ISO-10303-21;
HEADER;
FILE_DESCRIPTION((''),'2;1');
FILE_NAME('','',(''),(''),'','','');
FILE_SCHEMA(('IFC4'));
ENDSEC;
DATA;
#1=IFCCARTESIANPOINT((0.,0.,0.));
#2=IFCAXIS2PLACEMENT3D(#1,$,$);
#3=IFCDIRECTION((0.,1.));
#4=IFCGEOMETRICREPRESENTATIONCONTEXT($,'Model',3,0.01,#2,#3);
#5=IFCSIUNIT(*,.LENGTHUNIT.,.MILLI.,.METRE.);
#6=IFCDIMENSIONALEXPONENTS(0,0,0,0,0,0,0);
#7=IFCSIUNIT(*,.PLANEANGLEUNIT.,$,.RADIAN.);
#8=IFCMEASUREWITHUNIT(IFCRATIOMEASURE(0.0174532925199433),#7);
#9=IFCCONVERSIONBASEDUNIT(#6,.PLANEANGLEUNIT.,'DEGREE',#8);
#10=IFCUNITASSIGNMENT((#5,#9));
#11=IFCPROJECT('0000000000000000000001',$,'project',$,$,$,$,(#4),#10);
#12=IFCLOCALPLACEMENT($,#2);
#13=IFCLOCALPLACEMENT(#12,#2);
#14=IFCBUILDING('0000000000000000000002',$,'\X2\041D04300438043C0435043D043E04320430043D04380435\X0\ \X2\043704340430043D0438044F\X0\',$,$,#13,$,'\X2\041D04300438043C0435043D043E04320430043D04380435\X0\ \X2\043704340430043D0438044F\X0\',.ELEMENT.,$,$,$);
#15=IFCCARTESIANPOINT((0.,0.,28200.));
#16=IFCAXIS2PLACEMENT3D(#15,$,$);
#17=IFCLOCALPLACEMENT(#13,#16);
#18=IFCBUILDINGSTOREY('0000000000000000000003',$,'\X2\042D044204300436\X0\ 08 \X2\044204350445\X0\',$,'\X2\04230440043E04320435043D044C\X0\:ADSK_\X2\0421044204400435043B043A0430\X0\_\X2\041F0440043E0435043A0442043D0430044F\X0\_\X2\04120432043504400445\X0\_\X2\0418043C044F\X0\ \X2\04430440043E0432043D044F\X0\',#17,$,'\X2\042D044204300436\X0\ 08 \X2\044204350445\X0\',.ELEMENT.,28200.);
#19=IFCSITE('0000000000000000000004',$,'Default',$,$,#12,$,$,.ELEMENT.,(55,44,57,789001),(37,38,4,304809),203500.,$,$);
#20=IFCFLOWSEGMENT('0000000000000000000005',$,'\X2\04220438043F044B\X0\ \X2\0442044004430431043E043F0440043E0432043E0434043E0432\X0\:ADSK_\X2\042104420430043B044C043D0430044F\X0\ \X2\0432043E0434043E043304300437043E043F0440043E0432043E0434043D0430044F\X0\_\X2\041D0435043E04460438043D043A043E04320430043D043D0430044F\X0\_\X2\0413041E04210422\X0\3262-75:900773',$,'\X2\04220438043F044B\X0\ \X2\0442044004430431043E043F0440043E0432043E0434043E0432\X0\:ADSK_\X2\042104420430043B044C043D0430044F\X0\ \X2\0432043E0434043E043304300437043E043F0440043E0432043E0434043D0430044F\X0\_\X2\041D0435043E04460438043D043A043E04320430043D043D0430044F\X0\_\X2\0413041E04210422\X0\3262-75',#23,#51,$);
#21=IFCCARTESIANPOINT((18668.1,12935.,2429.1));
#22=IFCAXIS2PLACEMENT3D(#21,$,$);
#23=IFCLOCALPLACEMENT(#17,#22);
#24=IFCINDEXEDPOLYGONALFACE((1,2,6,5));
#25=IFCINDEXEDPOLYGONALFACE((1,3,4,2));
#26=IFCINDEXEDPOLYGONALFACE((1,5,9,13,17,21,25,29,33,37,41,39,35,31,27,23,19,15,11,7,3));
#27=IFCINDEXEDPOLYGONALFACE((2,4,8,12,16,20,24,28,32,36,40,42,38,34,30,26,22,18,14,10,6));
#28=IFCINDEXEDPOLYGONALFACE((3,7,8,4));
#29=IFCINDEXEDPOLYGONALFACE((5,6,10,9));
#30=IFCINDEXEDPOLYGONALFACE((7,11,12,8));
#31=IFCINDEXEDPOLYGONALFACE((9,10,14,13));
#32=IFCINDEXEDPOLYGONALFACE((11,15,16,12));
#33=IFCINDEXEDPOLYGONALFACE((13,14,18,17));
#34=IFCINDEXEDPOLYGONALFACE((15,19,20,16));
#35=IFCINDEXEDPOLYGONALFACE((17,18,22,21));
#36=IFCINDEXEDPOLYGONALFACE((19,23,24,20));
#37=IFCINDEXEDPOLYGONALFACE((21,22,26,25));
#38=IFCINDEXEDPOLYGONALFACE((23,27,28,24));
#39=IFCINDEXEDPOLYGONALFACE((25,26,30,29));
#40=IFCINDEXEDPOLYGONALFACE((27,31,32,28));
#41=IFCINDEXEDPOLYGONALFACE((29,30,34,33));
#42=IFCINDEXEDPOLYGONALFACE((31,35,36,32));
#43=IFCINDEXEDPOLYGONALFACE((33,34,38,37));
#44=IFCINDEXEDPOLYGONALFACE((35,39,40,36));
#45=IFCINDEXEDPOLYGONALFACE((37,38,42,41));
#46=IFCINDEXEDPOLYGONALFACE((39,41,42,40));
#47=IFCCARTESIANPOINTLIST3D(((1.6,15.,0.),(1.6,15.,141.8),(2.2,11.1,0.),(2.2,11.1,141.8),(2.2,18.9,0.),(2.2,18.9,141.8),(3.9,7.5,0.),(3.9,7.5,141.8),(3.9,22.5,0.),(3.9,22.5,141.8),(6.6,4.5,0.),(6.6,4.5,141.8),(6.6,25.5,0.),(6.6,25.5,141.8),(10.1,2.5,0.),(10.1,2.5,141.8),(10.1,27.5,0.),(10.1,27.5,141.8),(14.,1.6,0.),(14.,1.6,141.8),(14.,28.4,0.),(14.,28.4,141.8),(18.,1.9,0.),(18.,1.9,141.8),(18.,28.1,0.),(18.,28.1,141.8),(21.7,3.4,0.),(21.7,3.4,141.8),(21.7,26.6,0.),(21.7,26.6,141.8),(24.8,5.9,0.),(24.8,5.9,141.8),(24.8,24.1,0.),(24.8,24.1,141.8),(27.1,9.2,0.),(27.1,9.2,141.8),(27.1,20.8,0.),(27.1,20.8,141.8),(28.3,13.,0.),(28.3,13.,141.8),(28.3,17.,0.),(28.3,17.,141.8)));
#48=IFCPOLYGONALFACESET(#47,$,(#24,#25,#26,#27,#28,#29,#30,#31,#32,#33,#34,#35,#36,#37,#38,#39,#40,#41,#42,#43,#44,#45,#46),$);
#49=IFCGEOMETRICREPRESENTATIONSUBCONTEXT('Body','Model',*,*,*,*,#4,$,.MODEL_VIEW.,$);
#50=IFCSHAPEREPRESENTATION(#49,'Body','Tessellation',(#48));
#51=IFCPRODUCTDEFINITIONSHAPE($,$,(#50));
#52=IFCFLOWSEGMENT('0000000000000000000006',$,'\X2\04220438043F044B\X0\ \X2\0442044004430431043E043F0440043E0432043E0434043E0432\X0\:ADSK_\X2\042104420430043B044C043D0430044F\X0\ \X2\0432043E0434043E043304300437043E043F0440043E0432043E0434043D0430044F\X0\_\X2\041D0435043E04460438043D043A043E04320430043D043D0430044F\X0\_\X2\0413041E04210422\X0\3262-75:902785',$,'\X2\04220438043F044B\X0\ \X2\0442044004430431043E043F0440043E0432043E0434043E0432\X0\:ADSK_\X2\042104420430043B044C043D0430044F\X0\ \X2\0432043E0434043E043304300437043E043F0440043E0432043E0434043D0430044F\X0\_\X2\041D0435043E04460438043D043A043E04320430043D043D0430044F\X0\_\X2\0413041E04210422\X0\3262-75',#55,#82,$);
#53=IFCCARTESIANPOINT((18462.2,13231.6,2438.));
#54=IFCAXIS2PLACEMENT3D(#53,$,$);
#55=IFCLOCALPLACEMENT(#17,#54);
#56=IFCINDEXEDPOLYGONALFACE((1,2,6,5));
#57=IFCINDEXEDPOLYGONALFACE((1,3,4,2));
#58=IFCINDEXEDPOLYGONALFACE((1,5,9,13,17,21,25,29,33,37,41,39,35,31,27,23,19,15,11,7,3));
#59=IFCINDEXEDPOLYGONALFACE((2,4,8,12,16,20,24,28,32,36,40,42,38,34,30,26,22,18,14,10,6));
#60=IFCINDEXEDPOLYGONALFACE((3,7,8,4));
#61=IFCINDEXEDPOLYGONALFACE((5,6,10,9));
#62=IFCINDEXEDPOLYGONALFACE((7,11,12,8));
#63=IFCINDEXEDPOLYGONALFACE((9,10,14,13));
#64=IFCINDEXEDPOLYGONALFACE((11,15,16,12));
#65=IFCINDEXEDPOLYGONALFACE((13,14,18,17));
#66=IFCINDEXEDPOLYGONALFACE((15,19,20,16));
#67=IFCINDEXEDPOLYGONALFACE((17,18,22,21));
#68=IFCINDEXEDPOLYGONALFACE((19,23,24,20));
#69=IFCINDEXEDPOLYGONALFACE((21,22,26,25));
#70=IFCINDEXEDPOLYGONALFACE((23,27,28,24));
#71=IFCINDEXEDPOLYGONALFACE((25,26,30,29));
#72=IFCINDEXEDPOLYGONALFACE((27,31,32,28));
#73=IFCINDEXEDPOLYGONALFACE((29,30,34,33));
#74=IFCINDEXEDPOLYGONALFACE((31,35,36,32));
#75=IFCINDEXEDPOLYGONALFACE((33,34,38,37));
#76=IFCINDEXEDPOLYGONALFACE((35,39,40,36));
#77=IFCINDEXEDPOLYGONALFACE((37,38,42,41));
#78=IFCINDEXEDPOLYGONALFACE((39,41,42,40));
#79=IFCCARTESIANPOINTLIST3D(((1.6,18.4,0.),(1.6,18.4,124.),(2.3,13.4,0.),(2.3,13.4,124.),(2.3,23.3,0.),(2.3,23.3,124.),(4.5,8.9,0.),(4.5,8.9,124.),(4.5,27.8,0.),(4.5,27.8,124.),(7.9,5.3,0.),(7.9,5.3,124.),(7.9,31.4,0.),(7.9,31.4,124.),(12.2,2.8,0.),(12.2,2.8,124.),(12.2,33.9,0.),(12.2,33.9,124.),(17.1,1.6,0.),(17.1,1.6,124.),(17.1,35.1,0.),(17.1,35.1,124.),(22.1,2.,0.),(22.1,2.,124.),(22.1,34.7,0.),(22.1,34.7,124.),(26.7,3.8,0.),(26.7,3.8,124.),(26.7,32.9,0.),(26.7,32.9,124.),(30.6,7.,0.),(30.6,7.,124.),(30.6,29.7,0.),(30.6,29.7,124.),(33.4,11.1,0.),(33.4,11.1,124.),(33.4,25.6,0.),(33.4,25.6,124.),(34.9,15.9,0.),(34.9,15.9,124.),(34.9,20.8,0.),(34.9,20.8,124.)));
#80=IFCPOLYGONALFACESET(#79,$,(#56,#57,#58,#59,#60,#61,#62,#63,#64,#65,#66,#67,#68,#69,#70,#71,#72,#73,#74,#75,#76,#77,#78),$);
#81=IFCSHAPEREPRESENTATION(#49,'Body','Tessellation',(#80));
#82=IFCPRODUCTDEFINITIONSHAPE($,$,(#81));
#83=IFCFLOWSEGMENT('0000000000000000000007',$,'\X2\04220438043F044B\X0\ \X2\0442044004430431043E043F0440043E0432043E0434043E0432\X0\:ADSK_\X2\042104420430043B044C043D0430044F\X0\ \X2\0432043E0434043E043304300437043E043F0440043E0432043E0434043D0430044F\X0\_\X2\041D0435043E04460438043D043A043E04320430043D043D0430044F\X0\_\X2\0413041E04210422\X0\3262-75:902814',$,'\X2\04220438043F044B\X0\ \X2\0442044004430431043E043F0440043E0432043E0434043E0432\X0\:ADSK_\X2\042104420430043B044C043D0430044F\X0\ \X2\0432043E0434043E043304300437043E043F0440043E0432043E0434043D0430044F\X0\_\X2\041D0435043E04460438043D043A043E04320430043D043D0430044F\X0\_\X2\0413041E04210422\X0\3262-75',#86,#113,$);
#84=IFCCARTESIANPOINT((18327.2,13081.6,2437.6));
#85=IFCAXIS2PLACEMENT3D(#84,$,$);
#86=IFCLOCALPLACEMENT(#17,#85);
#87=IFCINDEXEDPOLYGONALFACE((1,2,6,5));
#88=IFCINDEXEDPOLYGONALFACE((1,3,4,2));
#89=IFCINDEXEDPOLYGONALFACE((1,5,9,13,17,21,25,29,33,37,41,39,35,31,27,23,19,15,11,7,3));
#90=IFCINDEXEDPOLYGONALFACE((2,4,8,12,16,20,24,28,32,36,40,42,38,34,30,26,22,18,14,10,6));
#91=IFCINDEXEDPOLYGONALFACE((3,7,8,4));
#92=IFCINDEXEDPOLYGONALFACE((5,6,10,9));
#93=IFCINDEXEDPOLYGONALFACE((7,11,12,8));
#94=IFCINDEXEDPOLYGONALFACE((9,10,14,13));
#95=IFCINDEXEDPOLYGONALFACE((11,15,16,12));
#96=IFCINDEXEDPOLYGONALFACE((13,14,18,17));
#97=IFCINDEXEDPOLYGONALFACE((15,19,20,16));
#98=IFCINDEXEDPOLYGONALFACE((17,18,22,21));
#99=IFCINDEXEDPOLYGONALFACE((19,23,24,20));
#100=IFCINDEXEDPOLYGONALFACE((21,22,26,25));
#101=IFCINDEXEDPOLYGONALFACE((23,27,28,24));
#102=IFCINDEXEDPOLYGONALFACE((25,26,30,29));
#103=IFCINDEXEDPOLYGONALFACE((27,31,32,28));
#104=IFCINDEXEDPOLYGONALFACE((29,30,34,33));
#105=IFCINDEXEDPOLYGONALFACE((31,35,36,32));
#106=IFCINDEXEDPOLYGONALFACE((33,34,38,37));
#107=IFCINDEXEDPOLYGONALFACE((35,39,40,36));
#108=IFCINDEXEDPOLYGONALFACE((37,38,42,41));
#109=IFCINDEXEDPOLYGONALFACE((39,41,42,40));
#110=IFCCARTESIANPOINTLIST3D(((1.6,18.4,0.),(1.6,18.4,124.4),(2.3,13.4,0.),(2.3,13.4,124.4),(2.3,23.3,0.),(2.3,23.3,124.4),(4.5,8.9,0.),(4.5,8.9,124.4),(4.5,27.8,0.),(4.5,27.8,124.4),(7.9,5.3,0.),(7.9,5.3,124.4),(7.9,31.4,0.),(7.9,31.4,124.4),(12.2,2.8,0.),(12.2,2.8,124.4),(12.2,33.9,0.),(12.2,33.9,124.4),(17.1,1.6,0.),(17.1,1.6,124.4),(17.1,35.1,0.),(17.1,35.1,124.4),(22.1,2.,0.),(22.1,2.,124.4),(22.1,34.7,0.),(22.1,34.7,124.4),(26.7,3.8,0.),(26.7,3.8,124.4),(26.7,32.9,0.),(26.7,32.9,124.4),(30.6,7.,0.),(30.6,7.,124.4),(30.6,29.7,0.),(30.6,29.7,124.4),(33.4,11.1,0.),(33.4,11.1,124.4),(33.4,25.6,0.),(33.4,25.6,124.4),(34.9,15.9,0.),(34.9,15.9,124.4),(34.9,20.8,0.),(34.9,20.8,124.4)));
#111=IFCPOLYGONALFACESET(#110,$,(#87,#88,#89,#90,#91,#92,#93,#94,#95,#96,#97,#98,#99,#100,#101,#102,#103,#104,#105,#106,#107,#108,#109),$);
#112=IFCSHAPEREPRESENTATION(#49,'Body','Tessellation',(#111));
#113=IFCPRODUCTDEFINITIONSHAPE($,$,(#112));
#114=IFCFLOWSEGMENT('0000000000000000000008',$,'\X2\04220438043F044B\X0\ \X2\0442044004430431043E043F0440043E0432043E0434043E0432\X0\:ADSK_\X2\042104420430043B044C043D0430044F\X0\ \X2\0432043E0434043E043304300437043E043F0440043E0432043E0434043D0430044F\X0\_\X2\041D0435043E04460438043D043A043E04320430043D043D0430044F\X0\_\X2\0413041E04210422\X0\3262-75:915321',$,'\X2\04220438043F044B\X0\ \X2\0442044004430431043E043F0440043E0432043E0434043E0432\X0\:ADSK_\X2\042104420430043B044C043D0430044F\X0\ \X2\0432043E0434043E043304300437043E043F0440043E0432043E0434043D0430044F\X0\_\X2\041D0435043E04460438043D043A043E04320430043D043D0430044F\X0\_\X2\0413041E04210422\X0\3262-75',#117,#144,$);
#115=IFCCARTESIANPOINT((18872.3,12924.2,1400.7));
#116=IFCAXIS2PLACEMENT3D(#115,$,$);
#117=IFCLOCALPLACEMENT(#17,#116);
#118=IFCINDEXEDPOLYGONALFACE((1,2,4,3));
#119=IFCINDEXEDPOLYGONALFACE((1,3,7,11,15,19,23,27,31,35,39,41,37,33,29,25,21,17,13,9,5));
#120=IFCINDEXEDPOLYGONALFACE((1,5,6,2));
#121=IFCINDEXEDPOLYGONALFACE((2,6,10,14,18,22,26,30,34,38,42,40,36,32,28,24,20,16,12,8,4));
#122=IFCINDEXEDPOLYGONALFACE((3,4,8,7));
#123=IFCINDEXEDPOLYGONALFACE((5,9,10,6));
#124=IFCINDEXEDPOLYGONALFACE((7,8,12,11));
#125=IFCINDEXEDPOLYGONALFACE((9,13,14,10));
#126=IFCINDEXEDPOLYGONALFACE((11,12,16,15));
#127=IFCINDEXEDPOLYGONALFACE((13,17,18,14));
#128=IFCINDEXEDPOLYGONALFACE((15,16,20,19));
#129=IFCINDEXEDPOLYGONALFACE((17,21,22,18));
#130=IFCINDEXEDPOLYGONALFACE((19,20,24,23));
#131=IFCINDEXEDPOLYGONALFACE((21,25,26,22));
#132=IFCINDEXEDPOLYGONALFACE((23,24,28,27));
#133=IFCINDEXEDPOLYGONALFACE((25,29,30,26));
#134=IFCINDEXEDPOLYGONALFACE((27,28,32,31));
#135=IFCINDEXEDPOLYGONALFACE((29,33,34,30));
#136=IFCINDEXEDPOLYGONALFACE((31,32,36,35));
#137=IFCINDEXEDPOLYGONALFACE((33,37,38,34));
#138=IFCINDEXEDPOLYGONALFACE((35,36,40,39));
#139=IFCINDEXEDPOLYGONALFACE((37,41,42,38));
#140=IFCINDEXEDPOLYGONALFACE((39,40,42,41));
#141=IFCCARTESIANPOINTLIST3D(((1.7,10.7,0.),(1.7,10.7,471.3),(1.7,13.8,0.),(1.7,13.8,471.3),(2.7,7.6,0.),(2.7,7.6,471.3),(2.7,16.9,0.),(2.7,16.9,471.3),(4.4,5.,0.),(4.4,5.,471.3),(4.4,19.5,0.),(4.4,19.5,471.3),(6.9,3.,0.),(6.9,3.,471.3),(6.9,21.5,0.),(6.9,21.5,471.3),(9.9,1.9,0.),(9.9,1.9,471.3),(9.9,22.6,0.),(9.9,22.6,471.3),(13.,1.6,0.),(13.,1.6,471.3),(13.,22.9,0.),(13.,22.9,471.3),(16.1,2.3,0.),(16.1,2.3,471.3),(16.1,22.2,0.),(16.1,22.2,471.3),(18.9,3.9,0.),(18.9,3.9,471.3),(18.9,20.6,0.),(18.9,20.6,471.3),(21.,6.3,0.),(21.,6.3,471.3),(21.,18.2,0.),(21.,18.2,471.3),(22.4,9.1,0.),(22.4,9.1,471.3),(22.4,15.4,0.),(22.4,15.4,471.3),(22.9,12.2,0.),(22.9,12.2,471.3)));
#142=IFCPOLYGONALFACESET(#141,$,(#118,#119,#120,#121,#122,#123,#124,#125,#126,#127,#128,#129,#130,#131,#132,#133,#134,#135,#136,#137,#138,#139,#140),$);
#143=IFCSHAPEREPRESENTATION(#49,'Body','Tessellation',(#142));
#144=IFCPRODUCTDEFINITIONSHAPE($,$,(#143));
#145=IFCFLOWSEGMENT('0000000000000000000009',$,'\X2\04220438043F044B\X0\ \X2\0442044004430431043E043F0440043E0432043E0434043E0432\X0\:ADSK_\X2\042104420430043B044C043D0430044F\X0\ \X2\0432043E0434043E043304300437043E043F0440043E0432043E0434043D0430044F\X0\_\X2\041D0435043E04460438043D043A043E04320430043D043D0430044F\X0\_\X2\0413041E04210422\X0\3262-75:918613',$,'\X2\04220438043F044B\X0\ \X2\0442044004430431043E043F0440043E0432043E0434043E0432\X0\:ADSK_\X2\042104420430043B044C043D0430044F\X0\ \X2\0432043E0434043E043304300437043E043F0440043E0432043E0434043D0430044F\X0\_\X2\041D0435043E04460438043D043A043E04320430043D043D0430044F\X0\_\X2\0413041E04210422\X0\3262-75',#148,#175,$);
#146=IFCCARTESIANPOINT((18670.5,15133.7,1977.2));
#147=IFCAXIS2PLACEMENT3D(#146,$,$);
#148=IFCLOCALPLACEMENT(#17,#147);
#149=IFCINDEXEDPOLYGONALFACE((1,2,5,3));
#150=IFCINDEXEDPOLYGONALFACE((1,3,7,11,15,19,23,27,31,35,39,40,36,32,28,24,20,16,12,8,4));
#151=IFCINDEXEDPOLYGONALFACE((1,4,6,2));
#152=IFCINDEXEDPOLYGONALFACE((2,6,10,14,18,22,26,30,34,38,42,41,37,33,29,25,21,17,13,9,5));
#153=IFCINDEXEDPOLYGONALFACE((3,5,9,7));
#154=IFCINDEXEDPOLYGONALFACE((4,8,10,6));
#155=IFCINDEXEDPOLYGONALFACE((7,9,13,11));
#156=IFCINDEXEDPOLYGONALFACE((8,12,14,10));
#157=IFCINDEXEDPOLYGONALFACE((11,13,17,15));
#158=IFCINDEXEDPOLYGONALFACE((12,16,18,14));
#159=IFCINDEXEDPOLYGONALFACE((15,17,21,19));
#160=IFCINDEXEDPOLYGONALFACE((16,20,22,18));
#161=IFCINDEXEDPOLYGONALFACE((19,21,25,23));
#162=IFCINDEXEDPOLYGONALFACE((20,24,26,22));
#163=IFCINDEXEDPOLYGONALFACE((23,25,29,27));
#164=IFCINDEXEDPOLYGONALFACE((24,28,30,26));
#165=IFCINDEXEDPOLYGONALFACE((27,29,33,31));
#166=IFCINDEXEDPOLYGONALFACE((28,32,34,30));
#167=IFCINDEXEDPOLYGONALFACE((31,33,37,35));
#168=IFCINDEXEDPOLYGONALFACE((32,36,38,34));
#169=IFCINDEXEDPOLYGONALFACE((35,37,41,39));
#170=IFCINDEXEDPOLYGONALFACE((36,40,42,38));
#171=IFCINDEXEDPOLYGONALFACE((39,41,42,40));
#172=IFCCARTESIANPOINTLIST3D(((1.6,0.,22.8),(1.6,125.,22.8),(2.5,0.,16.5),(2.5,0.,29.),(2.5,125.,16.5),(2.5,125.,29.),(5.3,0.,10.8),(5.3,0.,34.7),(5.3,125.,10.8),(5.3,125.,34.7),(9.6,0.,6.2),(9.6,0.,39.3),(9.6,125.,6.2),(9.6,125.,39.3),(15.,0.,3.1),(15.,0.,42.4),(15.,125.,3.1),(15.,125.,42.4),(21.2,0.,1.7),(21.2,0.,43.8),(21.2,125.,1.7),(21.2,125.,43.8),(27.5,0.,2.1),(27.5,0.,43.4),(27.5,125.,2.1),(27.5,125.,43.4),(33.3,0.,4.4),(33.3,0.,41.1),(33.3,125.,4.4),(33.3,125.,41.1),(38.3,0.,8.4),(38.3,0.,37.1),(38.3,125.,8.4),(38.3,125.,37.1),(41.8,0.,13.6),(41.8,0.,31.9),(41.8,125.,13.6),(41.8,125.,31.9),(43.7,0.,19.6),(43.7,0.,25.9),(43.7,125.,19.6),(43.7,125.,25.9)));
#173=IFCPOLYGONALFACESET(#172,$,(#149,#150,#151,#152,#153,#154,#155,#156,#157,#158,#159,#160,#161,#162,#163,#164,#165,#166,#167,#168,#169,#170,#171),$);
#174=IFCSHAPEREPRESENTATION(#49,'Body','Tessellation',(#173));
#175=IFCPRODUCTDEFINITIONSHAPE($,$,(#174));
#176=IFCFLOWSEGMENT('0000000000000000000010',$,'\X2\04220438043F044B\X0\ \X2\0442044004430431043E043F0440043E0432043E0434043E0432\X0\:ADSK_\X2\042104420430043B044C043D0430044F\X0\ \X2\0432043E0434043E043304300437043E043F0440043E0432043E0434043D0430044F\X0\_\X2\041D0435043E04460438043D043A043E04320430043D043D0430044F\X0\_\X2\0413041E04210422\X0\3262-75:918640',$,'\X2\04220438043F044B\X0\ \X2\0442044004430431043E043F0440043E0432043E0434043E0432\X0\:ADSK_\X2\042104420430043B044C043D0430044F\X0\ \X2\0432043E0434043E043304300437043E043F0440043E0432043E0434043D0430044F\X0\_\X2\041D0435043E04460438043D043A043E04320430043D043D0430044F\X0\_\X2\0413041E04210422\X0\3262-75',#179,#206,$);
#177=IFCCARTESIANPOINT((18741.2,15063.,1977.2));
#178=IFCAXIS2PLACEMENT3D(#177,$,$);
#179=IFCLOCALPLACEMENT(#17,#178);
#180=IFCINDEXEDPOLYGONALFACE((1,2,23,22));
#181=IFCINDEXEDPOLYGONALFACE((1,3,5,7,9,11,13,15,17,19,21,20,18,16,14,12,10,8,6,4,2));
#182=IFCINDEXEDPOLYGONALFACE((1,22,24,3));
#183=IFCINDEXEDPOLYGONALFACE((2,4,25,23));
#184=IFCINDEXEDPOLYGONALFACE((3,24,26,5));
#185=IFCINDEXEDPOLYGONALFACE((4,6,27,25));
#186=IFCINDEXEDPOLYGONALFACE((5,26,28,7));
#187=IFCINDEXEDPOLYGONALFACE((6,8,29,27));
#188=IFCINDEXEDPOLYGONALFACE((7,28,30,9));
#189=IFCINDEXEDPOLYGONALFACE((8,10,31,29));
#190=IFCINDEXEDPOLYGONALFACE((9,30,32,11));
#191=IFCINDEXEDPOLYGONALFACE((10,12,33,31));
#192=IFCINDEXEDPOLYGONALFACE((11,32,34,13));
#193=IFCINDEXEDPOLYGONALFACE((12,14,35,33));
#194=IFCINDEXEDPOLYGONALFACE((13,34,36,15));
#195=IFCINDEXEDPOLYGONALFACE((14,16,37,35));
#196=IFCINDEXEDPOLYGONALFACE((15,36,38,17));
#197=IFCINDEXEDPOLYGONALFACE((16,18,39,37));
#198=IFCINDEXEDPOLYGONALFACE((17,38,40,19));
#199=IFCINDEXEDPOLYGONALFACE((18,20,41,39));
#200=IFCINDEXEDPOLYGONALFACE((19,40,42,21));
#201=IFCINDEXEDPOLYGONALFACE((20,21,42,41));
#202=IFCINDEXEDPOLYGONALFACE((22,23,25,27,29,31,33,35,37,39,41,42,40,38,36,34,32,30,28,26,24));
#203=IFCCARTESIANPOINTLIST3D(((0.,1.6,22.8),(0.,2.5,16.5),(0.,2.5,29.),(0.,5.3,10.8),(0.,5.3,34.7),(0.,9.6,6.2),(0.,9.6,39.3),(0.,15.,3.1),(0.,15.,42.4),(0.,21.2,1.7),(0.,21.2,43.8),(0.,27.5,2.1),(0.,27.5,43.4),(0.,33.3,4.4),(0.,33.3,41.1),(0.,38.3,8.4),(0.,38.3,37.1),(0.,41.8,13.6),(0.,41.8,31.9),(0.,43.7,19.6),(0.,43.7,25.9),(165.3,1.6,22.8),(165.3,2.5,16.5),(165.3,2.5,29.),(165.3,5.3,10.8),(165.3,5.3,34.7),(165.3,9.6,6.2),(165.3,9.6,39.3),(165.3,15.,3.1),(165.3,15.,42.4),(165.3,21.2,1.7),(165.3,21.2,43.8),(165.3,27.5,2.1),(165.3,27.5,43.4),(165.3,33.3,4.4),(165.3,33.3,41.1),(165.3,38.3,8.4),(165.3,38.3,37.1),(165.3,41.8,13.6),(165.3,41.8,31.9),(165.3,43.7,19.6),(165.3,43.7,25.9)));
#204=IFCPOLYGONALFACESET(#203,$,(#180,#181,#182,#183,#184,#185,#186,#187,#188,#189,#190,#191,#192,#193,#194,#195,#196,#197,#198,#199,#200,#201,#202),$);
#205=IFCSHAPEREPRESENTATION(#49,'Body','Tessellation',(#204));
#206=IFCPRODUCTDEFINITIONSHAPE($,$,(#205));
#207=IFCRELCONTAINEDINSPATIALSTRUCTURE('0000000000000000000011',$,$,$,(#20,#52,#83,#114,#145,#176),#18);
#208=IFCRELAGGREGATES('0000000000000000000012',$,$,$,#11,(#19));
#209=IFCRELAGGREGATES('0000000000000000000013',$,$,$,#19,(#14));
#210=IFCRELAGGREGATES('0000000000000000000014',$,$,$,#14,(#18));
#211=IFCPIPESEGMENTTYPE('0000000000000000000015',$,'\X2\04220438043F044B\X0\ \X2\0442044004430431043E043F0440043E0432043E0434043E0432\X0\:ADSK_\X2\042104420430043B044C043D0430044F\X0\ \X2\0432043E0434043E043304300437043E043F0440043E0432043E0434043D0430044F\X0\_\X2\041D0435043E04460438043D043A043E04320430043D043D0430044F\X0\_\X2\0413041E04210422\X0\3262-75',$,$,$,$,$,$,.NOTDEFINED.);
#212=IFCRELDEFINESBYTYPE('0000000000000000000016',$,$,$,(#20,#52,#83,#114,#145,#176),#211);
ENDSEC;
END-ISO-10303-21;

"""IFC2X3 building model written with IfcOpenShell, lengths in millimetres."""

from ifc_helpers import new_model, entity, si_unit, converted_unit, direction, frame, origin, origin_2d_with_axis, place, context, subcontext, project, spatial, circle, extrude, type_object, element, save


model = new_model("IFC2X3")

# Units and contexts
model_context = context("Model", 3, precision=0.01, world=origin(), true_north=direction((0.0, 1.0)))
body_context = subcontext(model_context, "Body", "Model", "MODEL_VIEW")
ifc_project = project(units=[si_unit("LENGTHUNIT", "METRE", prefix="MILLI"), converted_unit("PLANEANGLEUNIT", "DEGREE", entity("IfcRatioMeasure", 0.0174532925199433), si_unit("PLANEANGLEUNIT", "RADIAN"), dimensions=[0, 0, 0, 0, 0, 0, 0])], contexts=[model_context])

# Site, building, storey
site_placement = place(None, origin())
site = spatial("IfcSite", under=ifc_project, at=site_placement, Name="Default", CompositionType="ELEMENT", RefLatitude=(55, 44, 57, 789001), RefLongitude=(37, 38, 4, 304809), RefElevation=203500.0)
building_placement = place(site_placement, origin())
building = spatial("IfcBuilding", under=site, at=building_placement, Name="Наименование здания", LongName="Наименование здания", CompositionType="ELEMENT")
storey_placement = place(building_placement, frame((0.0, 0.0, 28200.0)))
storey = spatial("IfcBuildingStorey", under=building, at=storey_placement, Name="Этаж 08 тех", ObjectType="Уровень:ADSK_Стрелка_Проектная_Вверх_Имя уровня", LongName="Этаж 08 тех", CompositionType="ELEMENT", Elevation=28200.0)

# Flow segments
pipe_segment_type_1 = type_object("IfcPipeSegmentType", Name="Типы трубопроводов:ADSK_Стальная водогазопроводная_Неоцинкованная_ГОСТ3262-75", PredefinedType="NOTDEFINED")
flow_segment_1_placement = place(storey_placement, frame((18668.1, 12935.0, 2429.1)))
element("IfcFlowSegment", 1, at=flow_segment_1_placement, inside=storey, type_object=pipe_segment_type_1, Name="Типы трубопроводов:ADSK_Стальная водогазопроводная_Неоцинкованная_ГОСТ3262-75:900773", ObjectType="Типы трубопроводов:ADSK_Стальная водогазопроводная_Неоцинкованная_ГОСТ3262-75", context=body_context, shape_type="SweptSolid", body=[
    extrude(circle(Radius=13.4, at=origin_2d_with_axis()), frame((15.0, 15.0, 0.0), z_axis=(0.0, 0.0, 1.0), x_axis=(-1.0, 0.0, 0.0)), (0.0, 0.0, 1.0), 141.8),
])
flow_segment_2_placement = place(storey_placement, frame((18462.2, 13231.6, 2438.0)))
element("IfcFlowSegment", 2, at=flow_segment_2_placement, inside=storey, type_object=pipe_segment_type_1, Name="Типы трубопроводов:ADSK_Стальная водогазопроводная_Неоцинкованная_ГОСТ3262-75:902785", ObjectType="Типы трубопроводов:ADSK_Стальная водогазопроводная_Неоцинкованная_ГОСТ3262-75", context=body_context, shape_type="SweptSolid", body=[
    extrude(circle(Radius=16.8, at=origin_2d_with_axis()), frame((18.4, 18.4, 0.0), z_axis=(0.0, 0.0, 1.0), x_axis=(-1.0, 0.0, 0.0)), (0.0, 0.0, 1.0), 124.0),
])
flow_segment_3_placement = place(storey_placement, frame((18327.2, 13081.6, 2437.6)))
element("IfcFlowSegment", 3, at=flow_segment_3_placement, inside=storey, type_object=pipe_segment_type_1, Name="Типы трубопроводов:ADSK_Стальная водогазопроводная_Неоцинкованная_ГОСТ3262-75:902814", ObjectType="Типы трубопроводов:ADSK_Стальная водогазопроводная_Неоцинкованная_ГОСТ3262-75", context=body_context, shape_type="SweptSolid", body=[
    extrude(circle(Radius=16.8, at=origin_2d_with_axis()), frame((18.4, 18.4, 0.0), z_axis=(0.0, 0.0, 1.0), x_axis=(-1.0, 0.0, 0.0)), (0.0, 0.0, 1.0), 124.4),
])
flow_segment_4_placement = place(storey_placement, frame((18872.3, 12924.2, 1400.7)))
element("IfcFlowSegment", 4, at=flow_segment_4_placement, inside=storey, type_object=pipe_segment_type_1, Name="Типы трубопроводов:ADSK_Стальная водогазопроводная_Неоцинкованная_ГОСТ3262-75:915321", ObjectType="Типы трубопроводов:ADSK_Стальная водогазопроводная_Неоцинкованная_ГОСТ3262-75", context=body_context, shape_type="SweptSolid", body=[
    extrude(circle(Radius=10.7, at=origin_2d_with_axis()), frame((12.2, 12.2, 0.0)), (0.0, 0.0, 1.0), 471.3),
])
flow_segment_5_placement = place(storey_placement, frame((18670.5, 15133.7, 1977.2)))
element("IfcFlowSegment", 5, at=flow_segment_5_placement, inside=storey, type_object=pipe_segment_type_1, Name="Типы трубопроводов:ADSK_Стальная водогазопроводная_Неоцинкованная_ГОСТ3262-75:918613", ObjectType="Типы трубопроводов:ADSK_Стальная водогазопроводная_Неоцинкованная_ГОСТ3262-75", context=body_context, shape_type="SweptSolid", body=[
    extrude(circle(Radius=21.1, at=origin_2d_with_axis()), frame((22.8, 0.0, 22.8), z_axis=(0.0, 1.0, 0.0), x_axis=(-1.0, 0.0, 0.0)), (0.0, 0.0, 1.0), 125.0),
])
flow_segment_6_placement = place(storey_placement, frame((18741.2, 15063.0, 1977.2)))
element("IfcFlowSegment", 6, at=flow_segment_6_placement, inside=storey, type_object=pipe_segment_type_1, Name="Типы трубопроводов:ADSK_Стальная водогазопроводная_Неоцинкованная_ГОСТ3262-75:918640", ObjectType="Типы трубопроводов:ADSK_Стальная водогазопроводная_Неоцинкованная_ГОСТ3262-75", context=body_context, shape_type="SweptSolid", body=[
    extrude(circle(Radius=21.1, at=origin_2d_with_axis()), frame((0.0, 22.8, 22.8), z_axis=(1.0, 0.0, 0.0), x_axis=(0.0, -1.0, 0.0)), (0.0, 0.0, 1.0), 165.3),
])

save(model, "model.ifc")
